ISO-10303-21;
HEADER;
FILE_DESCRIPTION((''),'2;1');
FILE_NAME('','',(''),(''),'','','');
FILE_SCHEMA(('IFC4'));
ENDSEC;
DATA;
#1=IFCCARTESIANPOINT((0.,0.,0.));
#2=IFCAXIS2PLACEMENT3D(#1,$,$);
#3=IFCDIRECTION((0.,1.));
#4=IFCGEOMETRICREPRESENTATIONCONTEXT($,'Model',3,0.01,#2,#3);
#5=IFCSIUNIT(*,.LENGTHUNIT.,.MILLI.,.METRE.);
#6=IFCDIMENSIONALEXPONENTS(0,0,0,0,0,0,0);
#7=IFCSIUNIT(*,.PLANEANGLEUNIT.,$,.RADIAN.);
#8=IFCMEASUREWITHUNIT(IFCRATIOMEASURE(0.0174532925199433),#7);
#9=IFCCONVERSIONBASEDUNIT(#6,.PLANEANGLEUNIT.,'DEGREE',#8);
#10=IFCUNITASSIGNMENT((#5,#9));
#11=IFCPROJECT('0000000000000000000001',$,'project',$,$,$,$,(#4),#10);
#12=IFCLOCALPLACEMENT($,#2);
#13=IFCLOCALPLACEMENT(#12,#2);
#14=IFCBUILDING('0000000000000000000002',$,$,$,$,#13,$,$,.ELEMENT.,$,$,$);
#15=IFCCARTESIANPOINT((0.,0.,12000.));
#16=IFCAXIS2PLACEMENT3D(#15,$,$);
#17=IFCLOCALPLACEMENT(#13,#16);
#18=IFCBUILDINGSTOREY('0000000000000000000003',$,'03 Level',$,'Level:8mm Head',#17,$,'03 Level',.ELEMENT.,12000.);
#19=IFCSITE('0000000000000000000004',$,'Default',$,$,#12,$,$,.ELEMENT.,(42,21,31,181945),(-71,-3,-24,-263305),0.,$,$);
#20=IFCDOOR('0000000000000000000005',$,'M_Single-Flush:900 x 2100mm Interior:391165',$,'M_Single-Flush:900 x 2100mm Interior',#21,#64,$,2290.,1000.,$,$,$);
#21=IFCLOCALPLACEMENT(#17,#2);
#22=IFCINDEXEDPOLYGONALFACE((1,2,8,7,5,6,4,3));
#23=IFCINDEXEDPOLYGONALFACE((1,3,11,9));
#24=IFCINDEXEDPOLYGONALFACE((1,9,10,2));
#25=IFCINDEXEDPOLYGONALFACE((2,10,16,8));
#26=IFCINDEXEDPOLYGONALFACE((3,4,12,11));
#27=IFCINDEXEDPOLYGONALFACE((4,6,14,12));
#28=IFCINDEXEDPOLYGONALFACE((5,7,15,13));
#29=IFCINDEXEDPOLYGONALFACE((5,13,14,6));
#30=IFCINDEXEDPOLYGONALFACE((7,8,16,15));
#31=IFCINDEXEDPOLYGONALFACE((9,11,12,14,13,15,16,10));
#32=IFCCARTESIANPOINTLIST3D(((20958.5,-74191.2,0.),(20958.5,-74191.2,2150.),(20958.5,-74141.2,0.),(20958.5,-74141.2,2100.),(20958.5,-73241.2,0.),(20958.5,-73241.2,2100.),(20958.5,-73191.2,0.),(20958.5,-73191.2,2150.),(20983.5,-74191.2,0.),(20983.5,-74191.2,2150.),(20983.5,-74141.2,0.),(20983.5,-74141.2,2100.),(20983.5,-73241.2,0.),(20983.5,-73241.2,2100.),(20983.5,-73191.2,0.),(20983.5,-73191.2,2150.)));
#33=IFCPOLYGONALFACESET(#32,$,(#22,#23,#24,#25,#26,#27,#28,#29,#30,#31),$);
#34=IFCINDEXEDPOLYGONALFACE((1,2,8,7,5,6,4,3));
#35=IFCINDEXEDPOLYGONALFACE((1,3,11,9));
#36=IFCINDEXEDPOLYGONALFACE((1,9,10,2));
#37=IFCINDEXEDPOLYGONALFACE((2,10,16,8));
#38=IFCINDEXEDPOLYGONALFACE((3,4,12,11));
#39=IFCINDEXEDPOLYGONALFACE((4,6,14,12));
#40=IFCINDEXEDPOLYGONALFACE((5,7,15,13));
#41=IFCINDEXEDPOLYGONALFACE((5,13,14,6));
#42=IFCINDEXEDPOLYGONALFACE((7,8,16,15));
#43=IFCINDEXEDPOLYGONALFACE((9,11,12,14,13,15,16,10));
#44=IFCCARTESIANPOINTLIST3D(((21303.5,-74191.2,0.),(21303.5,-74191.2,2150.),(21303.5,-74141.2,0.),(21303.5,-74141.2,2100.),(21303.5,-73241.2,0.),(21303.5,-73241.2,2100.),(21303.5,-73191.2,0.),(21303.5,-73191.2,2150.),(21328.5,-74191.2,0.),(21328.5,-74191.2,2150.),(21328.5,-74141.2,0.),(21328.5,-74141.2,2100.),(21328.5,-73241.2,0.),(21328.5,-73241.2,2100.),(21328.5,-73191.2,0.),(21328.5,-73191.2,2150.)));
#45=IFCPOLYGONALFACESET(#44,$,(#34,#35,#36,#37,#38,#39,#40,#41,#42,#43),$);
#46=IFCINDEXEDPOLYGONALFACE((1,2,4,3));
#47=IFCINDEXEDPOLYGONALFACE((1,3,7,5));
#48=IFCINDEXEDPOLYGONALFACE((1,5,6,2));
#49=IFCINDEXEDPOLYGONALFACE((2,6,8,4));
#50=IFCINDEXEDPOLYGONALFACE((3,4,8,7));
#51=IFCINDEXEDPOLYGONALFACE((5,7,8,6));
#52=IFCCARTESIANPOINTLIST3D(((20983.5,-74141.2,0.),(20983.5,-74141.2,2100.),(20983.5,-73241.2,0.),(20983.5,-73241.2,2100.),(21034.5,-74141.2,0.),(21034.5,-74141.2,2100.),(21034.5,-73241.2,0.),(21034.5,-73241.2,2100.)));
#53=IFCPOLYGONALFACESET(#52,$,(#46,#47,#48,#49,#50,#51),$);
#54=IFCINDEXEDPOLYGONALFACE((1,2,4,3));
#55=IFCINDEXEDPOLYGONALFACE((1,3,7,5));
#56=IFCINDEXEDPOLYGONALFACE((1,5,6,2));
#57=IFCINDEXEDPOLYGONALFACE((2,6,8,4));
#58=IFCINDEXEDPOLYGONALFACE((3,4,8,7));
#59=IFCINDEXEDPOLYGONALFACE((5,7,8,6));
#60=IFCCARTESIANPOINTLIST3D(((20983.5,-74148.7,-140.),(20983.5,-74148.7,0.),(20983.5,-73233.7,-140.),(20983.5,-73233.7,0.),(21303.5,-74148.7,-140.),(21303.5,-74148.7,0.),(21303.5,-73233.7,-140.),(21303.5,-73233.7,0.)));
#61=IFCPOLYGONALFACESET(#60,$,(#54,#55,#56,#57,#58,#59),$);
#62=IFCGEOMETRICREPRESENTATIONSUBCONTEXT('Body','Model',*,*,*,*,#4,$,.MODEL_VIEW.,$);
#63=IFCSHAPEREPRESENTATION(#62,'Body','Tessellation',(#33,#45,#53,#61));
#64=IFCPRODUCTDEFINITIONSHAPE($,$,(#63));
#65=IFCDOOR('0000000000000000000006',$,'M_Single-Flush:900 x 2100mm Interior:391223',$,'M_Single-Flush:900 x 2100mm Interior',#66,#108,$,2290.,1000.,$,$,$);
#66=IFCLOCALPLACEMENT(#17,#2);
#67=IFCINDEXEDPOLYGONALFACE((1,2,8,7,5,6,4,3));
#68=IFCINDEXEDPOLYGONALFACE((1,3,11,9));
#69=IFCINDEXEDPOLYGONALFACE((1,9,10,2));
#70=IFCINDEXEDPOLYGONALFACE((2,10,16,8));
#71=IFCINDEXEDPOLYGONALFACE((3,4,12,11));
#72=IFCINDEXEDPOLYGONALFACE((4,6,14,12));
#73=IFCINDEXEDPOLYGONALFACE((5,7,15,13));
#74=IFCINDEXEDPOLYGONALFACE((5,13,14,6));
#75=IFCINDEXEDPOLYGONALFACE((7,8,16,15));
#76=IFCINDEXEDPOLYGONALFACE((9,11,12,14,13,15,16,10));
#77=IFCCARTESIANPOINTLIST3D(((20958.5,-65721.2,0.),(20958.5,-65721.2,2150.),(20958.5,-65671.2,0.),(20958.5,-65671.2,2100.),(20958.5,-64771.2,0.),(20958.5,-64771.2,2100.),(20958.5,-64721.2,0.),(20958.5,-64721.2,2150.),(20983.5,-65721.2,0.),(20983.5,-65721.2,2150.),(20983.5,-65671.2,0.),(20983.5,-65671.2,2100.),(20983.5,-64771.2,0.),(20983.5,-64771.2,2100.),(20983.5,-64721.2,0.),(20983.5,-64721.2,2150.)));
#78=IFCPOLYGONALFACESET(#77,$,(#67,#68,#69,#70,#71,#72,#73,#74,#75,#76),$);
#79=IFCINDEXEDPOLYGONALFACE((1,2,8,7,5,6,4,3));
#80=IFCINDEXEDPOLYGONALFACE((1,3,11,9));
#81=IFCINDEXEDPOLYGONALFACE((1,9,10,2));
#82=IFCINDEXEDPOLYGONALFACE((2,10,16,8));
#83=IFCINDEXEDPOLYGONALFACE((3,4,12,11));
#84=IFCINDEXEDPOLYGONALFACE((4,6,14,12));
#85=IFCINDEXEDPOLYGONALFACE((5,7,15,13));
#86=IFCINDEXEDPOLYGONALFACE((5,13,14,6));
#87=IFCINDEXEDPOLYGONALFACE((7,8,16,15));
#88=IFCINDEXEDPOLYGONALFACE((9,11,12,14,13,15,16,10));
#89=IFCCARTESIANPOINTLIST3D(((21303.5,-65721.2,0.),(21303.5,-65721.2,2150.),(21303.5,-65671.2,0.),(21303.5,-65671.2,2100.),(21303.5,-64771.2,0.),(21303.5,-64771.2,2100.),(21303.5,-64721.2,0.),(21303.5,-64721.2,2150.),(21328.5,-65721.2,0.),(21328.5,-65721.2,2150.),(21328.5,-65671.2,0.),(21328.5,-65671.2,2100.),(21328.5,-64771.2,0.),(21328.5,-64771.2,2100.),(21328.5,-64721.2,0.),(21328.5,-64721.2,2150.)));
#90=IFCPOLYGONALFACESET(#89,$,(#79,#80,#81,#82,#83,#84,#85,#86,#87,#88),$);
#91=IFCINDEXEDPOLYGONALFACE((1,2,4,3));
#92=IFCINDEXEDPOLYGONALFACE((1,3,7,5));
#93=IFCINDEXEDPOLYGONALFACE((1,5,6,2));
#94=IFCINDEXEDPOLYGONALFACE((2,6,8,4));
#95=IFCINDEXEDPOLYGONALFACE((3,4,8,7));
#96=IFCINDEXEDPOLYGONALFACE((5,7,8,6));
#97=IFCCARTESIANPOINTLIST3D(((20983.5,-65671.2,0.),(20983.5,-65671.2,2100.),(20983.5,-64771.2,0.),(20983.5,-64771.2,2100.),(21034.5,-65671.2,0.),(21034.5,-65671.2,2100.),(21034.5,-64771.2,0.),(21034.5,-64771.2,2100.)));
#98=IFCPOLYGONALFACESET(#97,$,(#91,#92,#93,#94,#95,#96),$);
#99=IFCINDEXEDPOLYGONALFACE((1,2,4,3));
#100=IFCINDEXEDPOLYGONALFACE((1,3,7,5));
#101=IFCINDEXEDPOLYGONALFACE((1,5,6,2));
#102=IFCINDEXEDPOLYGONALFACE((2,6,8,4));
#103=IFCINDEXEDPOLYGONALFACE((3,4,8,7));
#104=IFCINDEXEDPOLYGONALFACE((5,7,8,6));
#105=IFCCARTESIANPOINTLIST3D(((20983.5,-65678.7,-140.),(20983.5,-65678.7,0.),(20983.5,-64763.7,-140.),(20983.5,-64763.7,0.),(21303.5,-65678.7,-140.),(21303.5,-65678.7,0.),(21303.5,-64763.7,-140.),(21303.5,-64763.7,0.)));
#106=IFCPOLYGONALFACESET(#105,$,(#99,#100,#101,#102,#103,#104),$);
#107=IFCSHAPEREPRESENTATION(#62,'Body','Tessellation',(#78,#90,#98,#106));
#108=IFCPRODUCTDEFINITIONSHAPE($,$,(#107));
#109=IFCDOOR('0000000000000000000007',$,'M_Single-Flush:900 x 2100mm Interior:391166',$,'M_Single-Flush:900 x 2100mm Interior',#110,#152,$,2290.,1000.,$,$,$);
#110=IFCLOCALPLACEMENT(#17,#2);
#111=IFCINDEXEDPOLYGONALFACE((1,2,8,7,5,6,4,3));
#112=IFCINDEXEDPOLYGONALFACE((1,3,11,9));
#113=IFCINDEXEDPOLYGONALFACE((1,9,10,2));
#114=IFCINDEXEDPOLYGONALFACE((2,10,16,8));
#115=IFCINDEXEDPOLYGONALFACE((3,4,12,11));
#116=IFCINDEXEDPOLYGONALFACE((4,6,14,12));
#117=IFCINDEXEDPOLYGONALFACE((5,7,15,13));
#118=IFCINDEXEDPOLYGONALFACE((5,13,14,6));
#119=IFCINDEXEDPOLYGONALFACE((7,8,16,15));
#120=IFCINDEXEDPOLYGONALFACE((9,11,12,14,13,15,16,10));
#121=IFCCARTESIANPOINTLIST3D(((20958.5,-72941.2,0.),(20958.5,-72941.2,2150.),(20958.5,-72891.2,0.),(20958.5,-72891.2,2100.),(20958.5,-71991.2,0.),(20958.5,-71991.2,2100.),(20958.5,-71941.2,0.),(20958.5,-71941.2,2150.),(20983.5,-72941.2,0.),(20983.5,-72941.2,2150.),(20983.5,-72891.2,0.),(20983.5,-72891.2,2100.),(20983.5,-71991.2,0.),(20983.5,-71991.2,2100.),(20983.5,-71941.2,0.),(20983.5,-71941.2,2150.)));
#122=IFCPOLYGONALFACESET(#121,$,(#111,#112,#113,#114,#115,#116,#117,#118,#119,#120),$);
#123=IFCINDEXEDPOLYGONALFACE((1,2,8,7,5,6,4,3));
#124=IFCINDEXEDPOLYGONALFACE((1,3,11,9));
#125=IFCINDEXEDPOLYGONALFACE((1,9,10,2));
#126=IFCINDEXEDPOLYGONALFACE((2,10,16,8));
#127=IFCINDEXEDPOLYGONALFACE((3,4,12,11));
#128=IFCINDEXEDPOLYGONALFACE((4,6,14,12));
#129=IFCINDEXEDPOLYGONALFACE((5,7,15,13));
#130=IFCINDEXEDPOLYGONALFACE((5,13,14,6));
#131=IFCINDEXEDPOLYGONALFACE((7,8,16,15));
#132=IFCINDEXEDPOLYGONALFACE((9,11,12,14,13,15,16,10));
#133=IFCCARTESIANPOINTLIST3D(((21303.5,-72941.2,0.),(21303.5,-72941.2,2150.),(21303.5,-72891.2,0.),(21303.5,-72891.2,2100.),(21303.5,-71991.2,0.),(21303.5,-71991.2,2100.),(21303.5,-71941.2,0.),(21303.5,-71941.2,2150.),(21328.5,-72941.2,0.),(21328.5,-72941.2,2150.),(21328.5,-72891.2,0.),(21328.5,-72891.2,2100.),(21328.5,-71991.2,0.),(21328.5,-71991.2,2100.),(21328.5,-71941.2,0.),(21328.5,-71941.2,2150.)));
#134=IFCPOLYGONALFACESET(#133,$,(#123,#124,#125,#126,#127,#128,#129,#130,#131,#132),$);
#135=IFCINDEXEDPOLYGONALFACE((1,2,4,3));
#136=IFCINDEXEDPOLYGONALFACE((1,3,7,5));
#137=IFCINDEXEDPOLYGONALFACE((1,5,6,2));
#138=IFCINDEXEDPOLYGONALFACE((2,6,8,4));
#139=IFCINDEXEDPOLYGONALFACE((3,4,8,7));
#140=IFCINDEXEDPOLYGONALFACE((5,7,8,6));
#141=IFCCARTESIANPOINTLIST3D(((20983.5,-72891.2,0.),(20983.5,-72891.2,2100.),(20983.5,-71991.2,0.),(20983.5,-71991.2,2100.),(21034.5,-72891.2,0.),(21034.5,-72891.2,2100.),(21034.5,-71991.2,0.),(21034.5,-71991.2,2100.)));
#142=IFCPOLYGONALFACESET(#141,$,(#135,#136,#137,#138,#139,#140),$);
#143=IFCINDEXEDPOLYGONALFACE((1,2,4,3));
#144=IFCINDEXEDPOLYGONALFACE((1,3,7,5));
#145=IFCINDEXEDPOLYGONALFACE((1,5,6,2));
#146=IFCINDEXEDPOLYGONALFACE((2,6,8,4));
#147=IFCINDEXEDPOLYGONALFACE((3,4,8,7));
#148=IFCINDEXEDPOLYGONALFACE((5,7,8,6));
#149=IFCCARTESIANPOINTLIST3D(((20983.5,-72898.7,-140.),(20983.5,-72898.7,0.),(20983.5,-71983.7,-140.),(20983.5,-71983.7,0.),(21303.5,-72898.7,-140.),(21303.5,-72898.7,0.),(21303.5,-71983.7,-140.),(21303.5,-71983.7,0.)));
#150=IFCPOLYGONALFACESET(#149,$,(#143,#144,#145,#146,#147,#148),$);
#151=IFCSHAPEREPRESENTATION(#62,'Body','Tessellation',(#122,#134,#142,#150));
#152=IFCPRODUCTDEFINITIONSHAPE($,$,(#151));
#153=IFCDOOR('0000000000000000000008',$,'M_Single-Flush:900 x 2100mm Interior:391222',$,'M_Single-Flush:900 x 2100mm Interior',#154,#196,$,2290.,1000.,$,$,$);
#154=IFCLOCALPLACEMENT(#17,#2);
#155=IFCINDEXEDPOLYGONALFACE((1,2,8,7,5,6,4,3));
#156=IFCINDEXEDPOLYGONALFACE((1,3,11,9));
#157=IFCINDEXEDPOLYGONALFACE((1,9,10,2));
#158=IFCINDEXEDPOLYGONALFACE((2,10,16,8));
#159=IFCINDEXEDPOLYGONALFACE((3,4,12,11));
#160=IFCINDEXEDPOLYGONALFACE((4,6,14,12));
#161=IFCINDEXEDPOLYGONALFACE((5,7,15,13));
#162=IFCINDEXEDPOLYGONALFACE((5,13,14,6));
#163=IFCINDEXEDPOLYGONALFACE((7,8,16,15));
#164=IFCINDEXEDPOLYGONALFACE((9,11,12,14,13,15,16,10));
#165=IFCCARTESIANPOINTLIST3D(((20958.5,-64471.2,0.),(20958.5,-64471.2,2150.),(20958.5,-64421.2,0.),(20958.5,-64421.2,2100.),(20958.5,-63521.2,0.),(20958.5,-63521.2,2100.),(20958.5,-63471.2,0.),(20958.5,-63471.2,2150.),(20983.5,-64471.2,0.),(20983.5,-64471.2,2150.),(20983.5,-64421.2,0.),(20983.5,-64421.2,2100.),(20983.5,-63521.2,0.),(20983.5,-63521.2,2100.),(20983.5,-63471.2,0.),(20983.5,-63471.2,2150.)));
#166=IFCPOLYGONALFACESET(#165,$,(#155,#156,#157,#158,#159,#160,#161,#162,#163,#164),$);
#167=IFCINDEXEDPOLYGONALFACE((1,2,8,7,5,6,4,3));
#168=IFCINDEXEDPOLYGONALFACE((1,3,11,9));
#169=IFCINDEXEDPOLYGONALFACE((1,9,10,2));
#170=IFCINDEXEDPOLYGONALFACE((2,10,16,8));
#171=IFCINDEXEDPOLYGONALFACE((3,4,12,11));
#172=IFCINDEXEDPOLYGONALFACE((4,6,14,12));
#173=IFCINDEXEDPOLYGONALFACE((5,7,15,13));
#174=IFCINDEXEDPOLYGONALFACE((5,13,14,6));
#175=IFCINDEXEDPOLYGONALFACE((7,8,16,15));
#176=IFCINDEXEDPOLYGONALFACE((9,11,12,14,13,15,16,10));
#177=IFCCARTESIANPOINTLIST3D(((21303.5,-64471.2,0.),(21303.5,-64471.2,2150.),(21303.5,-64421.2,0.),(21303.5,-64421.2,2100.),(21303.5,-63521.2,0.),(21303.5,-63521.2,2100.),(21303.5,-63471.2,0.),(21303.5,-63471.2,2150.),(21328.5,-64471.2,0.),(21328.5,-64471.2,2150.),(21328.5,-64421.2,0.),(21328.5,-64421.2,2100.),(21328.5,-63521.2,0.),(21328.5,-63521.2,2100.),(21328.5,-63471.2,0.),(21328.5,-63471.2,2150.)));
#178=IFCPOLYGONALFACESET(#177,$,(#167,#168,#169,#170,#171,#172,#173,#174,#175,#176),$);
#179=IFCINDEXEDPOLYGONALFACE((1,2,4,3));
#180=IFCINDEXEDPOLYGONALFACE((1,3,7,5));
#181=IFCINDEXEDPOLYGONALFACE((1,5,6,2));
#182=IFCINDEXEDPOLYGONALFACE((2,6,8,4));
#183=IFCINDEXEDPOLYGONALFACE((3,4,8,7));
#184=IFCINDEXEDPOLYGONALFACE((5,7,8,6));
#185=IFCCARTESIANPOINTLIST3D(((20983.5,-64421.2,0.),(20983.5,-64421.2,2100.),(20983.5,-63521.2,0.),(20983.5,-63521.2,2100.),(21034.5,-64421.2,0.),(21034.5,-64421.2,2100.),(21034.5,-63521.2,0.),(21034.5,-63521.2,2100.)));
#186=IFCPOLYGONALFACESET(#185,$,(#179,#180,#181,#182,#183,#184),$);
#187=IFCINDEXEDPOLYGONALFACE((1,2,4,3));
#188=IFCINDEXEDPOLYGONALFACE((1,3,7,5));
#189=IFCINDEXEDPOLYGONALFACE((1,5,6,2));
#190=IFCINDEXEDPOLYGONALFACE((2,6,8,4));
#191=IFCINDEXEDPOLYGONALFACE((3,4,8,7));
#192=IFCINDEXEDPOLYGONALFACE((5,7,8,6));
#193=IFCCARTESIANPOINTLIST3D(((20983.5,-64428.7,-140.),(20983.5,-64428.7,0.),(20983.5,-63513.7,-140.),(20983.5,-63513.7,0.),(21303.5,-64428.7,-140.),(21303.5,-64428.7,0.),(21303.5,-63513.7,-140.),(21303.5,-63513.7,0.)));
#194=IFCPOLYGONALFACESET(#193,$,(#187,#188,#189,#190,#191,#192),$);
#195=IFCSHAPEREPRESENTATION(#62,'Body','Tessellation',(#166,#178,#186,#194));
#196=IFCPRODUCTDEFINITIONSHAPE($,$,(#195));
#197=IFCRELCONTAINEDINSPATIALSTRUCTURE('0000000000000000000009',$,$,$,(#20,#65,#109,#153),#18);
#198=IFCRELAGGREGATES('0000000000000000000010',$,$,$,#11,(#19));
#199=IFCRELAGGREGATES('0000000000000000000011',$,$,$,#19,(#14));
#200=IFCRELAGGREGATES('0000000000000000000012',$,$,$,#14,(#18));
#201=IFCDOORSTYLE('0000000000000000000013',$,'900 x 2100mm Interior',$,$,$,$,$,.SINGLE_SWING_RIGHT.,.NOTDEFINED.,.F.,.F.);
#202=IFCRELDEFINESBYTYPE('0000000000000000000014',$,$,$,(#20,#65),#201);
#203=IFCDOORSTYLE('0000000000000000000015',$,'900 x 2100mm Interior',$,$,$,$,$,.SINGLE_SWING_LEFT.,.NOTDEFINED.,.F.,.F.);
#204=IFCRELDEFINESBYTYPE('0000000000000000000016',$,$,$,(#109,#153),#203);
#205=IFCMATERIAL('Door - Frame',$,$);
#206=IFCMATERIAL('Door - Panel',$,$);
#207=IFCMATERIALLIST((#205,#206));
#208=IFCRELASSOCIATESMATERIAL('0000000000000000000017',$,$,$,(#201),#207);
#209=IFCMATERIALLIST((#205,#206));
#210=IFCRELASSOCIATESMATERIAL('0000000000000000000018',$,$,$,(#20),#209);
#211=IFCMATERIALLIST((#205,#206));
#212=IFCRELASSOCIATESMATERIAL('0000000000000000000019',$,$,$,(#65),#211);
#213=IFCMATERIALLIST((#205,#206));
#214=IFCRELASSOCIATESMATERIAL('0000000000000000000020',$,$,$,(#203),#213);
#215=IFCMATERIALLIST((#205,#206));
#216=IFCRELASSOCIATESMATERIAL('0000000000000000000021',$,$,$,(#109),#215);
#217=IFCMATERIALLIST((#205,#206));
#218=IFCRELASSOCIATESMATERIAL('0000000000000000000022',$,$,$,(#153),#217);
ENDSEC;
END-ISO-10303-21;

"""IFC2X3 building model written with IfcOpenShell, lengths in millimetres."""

from ifc_helpers import new_model, entity, si_unit, converted_unit, direction, frame, frame_2d, origin, origin_2d_with_axis, place, context, subcontext, project, spatial, polyline, rectangle, outline, extrude, source, transform, mapped, material, material_list, type_object, type_shapes, element, save


model = new_model("IFC2X3")

# Units and contexts
model_context = context("Model", 3, precision=0.01, world=origin(), true_north=direction((0.0, 1.0)))
body_context = subcontext(model_context, "Body", "Model", "MODEL_VIEW")
ifc_project = project(units=[si_unit("LENGTHUNIT", "METRE", prefix="MILLI"), converted_unit("PLANEANGLEUNIT", "DEGREE", entity("IfcRatioMeasure", 0.0174532925199433), si_unit("PLANEANGLEUNIT", "RADIAN"), dimensions=[0, 0, 0, 0, 0, 0, 0])], contexts=[model_context])

# Site, building, storey
site_placement = place(None, origin())
site = spatial("IfcSite", under=ifc_project, at=site_placement, Name="Default", CompositionType="ELEMENT", RefLatitude=(42, 21, 31, 181945), RefLongitude=(-71, -3, -24, -263305), RefElevation=0.0)
building_placement = place(site_placement, origin())
building = spatial("IfcBuilding", under=site, at=building_placement, CompositionType="ELEMENT")
storey_placement = place(building_placement, frame((0.0, 0.0, 12000.0)))
storey = spatial("IfcBuildingStorey", under=building, at=storey_placement, Name="03 Level", ObjectType="Level:8mm Head", LongName="03 Level", CompositionType="ELEMENT", Elevation=12000.0)

# Doors
ifc_material_1 = material(Name="Door - Frame")
ifc_material_2 = material(Name="Door - Panel")
ifc_material_list_1 = material_list([ifc_material_1, ifc_material_2])
ifc_material_list_2 = material_list([ifc_material_1, ifc_material_2])
door_style_1 = type_object("IfcDoorStyle", Name="900 x 2100mm Interior", ConstructionType="NOTDEFINED", OperationType="SINGLE_SWING_RIGHT", ParameterTakesPrecedence=False, Sizeable=False, material=ifc_material_list_2)
shared_shape_1 = source(origin(), body_context, "Body", "SweptSolid", [
    extrude(outline(polyline([(-500.0, -1087.5), (500.0, -1087.5), (500.0, 1062.5), (450.0, 1062.5), (450.0, -1037.5), (-450.0, -1037.5), (-450.0, 1062.5), (-500.0, 1062.5), (-500.0, -1087.5)])), frame((450.0, 320.0, 1202.5), z_axis=(0.0, 1.0, 0.0), x_axis=(1.0, 0.0, 0.0)), (0.0, 0.0, 1.0), 25.0),
    extrude(outline(polyline([(-1087.5, -500.0), (1062.5, -500.0), (1062.5, -450.0), (-1037.5, -450.0), (-1037.5, 450.0), (1062.5, 450.0), (1062.5, 500.0), (-1087.5, 500.0), (-1087.5, -500.0)])), frame((450.0, -25.0, 1202.5), z_axis=(0.0, 1.0, 0.0), x_axis=(0.0, 0.0, -1.0)), (0.0, 0.0, 1.0), 25.0),
    extrude(rectangle(XDim=51.0, YDim=900.0, at=frame_2d((0.0, 0.0), x_axis=(1.0, 0.0))), frame((450.0, 294.5, 140.0), z_axis=(0.0, 0.0, 1.0), x_axis=(0.0, 1.0, 0.0)), (0.0, 0.0, 1.0), 2100.0),
    extrude(rectangle(XDim=915.0, YDim=320.0, at=origin_2d_with_axis()), frame((450.0, 160.0, 0.0), z_axis=(0.0, 0.0, 1.0), x_axis=(-1.0, 0.0, 0.0)), (0.0, 0.0, 1.0), 140.0),
])
type_shapes(door_style_1, [shared_shape_1])
door_1_placement = place(storey_placement, frame((21303.5, -74141.2, -140.0), z_axis=(0.0, 0.0, 1.0), x_axis=(0.0, 1.0, 0.0)))
element("IfcDoor", 1, at=door_1_placement, inside=storey, type_object=door_style_1, material=ifc_material_list_1, Name="M_Single-Flush:900 x 2100mm Interior:391165", ObjectType="M_Single-Flush:900 x 2100mm Interior", OverallHeight=2290.0, OverallWidth=1000.0, context=body_context, shape_type="MappedRepresentation", body=[
    mapped(shared_shape_1, transform((0.0, 0.0, 0.0), scale=1.0)),
])
ifc_material_list_3 = material_list([ifc_material_1, ifc_material_2])
door_2_placement = place(storey_placement, frame((21303.5, -65671.2, -140.0), z_axis=(0.0, 0.0, 1.0), x_axis=(0.0, 1.0, 0.0)))
element("IfcDoor", 2, at=door_2_placement, inside=storey, type_object=door_style_1, material=ifc_material_list_3, Name="M_Single-Flush:900 x 2100mm Interior:391223", ObjectType="M_Single-Flush:900 x 2100mm Interior", OverallHeight=2290.0, OverallWidth=1000.0, context=body_context, shape_type="MappedRepresentation", body=[
    mapped(shared_shape_1, transform((0.0, 0.0, 0.0), scale=1.0)),
])
ifc_material_list_4 = material_list([ifc_material_1, ifc_material_2])
ifc_material_list_5 = material_list([ifc_material_1, ifc_material_2])
door_style_2 = type_object("IfcDoorStyle", Name="900 x 2100mm Interior", ConstructionType="NOTDEFINED", OperationType="SINGLE_SWING_LEFT", ParameterTakesPrecedence=False, Sizeable=False, material=ifc_material_list_5)
shared_shape_2 = source(origin(), body_context, "Body", "SweptSolid", [
    extrude(outline(polyline([(-500.0, -1087.5), (500.0, -1087.5), (500.0, 1062.5), (450.0, 1062.5), (450.0, -1037.5), (-450.0, -1037.5), (-450.0, 1062.5), (-500.0, 1062.5), (-500.0, -1087.5)])), frame((450.0, 345.0, 1202.5), z_axis=(0.0, -1.0, 0.0), x_axis=(-1.0, 0.0, 0.0)), (0.0, 0.0, 1.0), 25.0),
    extrude(outline(polyline([(-1087.5, -500.0), (1062.5, -500.0), (1062.5, -450.0), (-1037.5, -450.0), (-1037.5, 450.0), (1062.5, 450.0), (1062.5, 500.0), (-1087.5, 500.0), (-1087.5, -500.0)])), frame((450.0, 0.0, 1202.5), z_axis=(0.0, -1.0, 0.0), x_axis=(0.0, 0.0, -1.0)), (0.0, 0.0, 1.0), 25.0),
    extrude(rectangle(XDim=900.0, YDim=51.0, at=origin_2d_with_axis()), frame((450.0, 294.5, 140.0)), (0.0, 0.0, 1.0), 2100.0),
    extrude(rectangle(XDim=320.0, YDim=915.0, at=origin_2d_with_axis()), frame((450.0, 160.0, 0.0), z_axis=(0.0, 0.0, 1.0), x_axis=(0.0, -1.0, 0.0)), (0.0, 0.0, 1.0), 140.0),
])
type_shapes(door_style_2, [shared_shape_2])
door_3_placement = place(storey_placement, frame((21303.5, -72891.2, -140.0), z_axis=(0.0, 0.0, 1.0), x_axis=(0.0, 1.0, 0.0)))
element("IfcDoor", 3, at=door_3_placement, inside=storey, type_object=door_style_2, material=ifc_material_list_4, Name="M_Single-Flush:900 x 2100mm Interior:391166", ObjectType="M_Single-Flush:900 x 2100mm Interior", OverallHeight=2290.0, OverallWidth=1000.0, context=body_context, shape_type="MappedRepresentation", body=[
    mapped(shared_shape_2, transform((0.0, 0.0, 0.0), scale=1.0)),
])
ifc_material_list_6 = material_list([ifc_material_1, ifc_material_2])
door_4_placement = place(storey_placement, frame((21303.5, -64421.2, -140.0), z_axis=(0.0, 0.0, 1.0), x_axis=(0.0, 1.0, 0.0)))
element("IfcDoor", 4, at=door_4_placement, inside=storey, type_object=door_style_2, material=ifc_material_list_6, Name="M_Single-Flush:900 x 2100mm Interior:391222", ObjectType="M_Single-Flush:900 x 2100mm Interior", OverallHeight=2290.0, OverallWidth=1000.0, context=body_context, shape_type="MappedRepresentation", body=[
    mapped(shared_shape_2, transform((0.0, 0.0, 0.0), scale=1.0)),
])

save(model, "model.ifc")
